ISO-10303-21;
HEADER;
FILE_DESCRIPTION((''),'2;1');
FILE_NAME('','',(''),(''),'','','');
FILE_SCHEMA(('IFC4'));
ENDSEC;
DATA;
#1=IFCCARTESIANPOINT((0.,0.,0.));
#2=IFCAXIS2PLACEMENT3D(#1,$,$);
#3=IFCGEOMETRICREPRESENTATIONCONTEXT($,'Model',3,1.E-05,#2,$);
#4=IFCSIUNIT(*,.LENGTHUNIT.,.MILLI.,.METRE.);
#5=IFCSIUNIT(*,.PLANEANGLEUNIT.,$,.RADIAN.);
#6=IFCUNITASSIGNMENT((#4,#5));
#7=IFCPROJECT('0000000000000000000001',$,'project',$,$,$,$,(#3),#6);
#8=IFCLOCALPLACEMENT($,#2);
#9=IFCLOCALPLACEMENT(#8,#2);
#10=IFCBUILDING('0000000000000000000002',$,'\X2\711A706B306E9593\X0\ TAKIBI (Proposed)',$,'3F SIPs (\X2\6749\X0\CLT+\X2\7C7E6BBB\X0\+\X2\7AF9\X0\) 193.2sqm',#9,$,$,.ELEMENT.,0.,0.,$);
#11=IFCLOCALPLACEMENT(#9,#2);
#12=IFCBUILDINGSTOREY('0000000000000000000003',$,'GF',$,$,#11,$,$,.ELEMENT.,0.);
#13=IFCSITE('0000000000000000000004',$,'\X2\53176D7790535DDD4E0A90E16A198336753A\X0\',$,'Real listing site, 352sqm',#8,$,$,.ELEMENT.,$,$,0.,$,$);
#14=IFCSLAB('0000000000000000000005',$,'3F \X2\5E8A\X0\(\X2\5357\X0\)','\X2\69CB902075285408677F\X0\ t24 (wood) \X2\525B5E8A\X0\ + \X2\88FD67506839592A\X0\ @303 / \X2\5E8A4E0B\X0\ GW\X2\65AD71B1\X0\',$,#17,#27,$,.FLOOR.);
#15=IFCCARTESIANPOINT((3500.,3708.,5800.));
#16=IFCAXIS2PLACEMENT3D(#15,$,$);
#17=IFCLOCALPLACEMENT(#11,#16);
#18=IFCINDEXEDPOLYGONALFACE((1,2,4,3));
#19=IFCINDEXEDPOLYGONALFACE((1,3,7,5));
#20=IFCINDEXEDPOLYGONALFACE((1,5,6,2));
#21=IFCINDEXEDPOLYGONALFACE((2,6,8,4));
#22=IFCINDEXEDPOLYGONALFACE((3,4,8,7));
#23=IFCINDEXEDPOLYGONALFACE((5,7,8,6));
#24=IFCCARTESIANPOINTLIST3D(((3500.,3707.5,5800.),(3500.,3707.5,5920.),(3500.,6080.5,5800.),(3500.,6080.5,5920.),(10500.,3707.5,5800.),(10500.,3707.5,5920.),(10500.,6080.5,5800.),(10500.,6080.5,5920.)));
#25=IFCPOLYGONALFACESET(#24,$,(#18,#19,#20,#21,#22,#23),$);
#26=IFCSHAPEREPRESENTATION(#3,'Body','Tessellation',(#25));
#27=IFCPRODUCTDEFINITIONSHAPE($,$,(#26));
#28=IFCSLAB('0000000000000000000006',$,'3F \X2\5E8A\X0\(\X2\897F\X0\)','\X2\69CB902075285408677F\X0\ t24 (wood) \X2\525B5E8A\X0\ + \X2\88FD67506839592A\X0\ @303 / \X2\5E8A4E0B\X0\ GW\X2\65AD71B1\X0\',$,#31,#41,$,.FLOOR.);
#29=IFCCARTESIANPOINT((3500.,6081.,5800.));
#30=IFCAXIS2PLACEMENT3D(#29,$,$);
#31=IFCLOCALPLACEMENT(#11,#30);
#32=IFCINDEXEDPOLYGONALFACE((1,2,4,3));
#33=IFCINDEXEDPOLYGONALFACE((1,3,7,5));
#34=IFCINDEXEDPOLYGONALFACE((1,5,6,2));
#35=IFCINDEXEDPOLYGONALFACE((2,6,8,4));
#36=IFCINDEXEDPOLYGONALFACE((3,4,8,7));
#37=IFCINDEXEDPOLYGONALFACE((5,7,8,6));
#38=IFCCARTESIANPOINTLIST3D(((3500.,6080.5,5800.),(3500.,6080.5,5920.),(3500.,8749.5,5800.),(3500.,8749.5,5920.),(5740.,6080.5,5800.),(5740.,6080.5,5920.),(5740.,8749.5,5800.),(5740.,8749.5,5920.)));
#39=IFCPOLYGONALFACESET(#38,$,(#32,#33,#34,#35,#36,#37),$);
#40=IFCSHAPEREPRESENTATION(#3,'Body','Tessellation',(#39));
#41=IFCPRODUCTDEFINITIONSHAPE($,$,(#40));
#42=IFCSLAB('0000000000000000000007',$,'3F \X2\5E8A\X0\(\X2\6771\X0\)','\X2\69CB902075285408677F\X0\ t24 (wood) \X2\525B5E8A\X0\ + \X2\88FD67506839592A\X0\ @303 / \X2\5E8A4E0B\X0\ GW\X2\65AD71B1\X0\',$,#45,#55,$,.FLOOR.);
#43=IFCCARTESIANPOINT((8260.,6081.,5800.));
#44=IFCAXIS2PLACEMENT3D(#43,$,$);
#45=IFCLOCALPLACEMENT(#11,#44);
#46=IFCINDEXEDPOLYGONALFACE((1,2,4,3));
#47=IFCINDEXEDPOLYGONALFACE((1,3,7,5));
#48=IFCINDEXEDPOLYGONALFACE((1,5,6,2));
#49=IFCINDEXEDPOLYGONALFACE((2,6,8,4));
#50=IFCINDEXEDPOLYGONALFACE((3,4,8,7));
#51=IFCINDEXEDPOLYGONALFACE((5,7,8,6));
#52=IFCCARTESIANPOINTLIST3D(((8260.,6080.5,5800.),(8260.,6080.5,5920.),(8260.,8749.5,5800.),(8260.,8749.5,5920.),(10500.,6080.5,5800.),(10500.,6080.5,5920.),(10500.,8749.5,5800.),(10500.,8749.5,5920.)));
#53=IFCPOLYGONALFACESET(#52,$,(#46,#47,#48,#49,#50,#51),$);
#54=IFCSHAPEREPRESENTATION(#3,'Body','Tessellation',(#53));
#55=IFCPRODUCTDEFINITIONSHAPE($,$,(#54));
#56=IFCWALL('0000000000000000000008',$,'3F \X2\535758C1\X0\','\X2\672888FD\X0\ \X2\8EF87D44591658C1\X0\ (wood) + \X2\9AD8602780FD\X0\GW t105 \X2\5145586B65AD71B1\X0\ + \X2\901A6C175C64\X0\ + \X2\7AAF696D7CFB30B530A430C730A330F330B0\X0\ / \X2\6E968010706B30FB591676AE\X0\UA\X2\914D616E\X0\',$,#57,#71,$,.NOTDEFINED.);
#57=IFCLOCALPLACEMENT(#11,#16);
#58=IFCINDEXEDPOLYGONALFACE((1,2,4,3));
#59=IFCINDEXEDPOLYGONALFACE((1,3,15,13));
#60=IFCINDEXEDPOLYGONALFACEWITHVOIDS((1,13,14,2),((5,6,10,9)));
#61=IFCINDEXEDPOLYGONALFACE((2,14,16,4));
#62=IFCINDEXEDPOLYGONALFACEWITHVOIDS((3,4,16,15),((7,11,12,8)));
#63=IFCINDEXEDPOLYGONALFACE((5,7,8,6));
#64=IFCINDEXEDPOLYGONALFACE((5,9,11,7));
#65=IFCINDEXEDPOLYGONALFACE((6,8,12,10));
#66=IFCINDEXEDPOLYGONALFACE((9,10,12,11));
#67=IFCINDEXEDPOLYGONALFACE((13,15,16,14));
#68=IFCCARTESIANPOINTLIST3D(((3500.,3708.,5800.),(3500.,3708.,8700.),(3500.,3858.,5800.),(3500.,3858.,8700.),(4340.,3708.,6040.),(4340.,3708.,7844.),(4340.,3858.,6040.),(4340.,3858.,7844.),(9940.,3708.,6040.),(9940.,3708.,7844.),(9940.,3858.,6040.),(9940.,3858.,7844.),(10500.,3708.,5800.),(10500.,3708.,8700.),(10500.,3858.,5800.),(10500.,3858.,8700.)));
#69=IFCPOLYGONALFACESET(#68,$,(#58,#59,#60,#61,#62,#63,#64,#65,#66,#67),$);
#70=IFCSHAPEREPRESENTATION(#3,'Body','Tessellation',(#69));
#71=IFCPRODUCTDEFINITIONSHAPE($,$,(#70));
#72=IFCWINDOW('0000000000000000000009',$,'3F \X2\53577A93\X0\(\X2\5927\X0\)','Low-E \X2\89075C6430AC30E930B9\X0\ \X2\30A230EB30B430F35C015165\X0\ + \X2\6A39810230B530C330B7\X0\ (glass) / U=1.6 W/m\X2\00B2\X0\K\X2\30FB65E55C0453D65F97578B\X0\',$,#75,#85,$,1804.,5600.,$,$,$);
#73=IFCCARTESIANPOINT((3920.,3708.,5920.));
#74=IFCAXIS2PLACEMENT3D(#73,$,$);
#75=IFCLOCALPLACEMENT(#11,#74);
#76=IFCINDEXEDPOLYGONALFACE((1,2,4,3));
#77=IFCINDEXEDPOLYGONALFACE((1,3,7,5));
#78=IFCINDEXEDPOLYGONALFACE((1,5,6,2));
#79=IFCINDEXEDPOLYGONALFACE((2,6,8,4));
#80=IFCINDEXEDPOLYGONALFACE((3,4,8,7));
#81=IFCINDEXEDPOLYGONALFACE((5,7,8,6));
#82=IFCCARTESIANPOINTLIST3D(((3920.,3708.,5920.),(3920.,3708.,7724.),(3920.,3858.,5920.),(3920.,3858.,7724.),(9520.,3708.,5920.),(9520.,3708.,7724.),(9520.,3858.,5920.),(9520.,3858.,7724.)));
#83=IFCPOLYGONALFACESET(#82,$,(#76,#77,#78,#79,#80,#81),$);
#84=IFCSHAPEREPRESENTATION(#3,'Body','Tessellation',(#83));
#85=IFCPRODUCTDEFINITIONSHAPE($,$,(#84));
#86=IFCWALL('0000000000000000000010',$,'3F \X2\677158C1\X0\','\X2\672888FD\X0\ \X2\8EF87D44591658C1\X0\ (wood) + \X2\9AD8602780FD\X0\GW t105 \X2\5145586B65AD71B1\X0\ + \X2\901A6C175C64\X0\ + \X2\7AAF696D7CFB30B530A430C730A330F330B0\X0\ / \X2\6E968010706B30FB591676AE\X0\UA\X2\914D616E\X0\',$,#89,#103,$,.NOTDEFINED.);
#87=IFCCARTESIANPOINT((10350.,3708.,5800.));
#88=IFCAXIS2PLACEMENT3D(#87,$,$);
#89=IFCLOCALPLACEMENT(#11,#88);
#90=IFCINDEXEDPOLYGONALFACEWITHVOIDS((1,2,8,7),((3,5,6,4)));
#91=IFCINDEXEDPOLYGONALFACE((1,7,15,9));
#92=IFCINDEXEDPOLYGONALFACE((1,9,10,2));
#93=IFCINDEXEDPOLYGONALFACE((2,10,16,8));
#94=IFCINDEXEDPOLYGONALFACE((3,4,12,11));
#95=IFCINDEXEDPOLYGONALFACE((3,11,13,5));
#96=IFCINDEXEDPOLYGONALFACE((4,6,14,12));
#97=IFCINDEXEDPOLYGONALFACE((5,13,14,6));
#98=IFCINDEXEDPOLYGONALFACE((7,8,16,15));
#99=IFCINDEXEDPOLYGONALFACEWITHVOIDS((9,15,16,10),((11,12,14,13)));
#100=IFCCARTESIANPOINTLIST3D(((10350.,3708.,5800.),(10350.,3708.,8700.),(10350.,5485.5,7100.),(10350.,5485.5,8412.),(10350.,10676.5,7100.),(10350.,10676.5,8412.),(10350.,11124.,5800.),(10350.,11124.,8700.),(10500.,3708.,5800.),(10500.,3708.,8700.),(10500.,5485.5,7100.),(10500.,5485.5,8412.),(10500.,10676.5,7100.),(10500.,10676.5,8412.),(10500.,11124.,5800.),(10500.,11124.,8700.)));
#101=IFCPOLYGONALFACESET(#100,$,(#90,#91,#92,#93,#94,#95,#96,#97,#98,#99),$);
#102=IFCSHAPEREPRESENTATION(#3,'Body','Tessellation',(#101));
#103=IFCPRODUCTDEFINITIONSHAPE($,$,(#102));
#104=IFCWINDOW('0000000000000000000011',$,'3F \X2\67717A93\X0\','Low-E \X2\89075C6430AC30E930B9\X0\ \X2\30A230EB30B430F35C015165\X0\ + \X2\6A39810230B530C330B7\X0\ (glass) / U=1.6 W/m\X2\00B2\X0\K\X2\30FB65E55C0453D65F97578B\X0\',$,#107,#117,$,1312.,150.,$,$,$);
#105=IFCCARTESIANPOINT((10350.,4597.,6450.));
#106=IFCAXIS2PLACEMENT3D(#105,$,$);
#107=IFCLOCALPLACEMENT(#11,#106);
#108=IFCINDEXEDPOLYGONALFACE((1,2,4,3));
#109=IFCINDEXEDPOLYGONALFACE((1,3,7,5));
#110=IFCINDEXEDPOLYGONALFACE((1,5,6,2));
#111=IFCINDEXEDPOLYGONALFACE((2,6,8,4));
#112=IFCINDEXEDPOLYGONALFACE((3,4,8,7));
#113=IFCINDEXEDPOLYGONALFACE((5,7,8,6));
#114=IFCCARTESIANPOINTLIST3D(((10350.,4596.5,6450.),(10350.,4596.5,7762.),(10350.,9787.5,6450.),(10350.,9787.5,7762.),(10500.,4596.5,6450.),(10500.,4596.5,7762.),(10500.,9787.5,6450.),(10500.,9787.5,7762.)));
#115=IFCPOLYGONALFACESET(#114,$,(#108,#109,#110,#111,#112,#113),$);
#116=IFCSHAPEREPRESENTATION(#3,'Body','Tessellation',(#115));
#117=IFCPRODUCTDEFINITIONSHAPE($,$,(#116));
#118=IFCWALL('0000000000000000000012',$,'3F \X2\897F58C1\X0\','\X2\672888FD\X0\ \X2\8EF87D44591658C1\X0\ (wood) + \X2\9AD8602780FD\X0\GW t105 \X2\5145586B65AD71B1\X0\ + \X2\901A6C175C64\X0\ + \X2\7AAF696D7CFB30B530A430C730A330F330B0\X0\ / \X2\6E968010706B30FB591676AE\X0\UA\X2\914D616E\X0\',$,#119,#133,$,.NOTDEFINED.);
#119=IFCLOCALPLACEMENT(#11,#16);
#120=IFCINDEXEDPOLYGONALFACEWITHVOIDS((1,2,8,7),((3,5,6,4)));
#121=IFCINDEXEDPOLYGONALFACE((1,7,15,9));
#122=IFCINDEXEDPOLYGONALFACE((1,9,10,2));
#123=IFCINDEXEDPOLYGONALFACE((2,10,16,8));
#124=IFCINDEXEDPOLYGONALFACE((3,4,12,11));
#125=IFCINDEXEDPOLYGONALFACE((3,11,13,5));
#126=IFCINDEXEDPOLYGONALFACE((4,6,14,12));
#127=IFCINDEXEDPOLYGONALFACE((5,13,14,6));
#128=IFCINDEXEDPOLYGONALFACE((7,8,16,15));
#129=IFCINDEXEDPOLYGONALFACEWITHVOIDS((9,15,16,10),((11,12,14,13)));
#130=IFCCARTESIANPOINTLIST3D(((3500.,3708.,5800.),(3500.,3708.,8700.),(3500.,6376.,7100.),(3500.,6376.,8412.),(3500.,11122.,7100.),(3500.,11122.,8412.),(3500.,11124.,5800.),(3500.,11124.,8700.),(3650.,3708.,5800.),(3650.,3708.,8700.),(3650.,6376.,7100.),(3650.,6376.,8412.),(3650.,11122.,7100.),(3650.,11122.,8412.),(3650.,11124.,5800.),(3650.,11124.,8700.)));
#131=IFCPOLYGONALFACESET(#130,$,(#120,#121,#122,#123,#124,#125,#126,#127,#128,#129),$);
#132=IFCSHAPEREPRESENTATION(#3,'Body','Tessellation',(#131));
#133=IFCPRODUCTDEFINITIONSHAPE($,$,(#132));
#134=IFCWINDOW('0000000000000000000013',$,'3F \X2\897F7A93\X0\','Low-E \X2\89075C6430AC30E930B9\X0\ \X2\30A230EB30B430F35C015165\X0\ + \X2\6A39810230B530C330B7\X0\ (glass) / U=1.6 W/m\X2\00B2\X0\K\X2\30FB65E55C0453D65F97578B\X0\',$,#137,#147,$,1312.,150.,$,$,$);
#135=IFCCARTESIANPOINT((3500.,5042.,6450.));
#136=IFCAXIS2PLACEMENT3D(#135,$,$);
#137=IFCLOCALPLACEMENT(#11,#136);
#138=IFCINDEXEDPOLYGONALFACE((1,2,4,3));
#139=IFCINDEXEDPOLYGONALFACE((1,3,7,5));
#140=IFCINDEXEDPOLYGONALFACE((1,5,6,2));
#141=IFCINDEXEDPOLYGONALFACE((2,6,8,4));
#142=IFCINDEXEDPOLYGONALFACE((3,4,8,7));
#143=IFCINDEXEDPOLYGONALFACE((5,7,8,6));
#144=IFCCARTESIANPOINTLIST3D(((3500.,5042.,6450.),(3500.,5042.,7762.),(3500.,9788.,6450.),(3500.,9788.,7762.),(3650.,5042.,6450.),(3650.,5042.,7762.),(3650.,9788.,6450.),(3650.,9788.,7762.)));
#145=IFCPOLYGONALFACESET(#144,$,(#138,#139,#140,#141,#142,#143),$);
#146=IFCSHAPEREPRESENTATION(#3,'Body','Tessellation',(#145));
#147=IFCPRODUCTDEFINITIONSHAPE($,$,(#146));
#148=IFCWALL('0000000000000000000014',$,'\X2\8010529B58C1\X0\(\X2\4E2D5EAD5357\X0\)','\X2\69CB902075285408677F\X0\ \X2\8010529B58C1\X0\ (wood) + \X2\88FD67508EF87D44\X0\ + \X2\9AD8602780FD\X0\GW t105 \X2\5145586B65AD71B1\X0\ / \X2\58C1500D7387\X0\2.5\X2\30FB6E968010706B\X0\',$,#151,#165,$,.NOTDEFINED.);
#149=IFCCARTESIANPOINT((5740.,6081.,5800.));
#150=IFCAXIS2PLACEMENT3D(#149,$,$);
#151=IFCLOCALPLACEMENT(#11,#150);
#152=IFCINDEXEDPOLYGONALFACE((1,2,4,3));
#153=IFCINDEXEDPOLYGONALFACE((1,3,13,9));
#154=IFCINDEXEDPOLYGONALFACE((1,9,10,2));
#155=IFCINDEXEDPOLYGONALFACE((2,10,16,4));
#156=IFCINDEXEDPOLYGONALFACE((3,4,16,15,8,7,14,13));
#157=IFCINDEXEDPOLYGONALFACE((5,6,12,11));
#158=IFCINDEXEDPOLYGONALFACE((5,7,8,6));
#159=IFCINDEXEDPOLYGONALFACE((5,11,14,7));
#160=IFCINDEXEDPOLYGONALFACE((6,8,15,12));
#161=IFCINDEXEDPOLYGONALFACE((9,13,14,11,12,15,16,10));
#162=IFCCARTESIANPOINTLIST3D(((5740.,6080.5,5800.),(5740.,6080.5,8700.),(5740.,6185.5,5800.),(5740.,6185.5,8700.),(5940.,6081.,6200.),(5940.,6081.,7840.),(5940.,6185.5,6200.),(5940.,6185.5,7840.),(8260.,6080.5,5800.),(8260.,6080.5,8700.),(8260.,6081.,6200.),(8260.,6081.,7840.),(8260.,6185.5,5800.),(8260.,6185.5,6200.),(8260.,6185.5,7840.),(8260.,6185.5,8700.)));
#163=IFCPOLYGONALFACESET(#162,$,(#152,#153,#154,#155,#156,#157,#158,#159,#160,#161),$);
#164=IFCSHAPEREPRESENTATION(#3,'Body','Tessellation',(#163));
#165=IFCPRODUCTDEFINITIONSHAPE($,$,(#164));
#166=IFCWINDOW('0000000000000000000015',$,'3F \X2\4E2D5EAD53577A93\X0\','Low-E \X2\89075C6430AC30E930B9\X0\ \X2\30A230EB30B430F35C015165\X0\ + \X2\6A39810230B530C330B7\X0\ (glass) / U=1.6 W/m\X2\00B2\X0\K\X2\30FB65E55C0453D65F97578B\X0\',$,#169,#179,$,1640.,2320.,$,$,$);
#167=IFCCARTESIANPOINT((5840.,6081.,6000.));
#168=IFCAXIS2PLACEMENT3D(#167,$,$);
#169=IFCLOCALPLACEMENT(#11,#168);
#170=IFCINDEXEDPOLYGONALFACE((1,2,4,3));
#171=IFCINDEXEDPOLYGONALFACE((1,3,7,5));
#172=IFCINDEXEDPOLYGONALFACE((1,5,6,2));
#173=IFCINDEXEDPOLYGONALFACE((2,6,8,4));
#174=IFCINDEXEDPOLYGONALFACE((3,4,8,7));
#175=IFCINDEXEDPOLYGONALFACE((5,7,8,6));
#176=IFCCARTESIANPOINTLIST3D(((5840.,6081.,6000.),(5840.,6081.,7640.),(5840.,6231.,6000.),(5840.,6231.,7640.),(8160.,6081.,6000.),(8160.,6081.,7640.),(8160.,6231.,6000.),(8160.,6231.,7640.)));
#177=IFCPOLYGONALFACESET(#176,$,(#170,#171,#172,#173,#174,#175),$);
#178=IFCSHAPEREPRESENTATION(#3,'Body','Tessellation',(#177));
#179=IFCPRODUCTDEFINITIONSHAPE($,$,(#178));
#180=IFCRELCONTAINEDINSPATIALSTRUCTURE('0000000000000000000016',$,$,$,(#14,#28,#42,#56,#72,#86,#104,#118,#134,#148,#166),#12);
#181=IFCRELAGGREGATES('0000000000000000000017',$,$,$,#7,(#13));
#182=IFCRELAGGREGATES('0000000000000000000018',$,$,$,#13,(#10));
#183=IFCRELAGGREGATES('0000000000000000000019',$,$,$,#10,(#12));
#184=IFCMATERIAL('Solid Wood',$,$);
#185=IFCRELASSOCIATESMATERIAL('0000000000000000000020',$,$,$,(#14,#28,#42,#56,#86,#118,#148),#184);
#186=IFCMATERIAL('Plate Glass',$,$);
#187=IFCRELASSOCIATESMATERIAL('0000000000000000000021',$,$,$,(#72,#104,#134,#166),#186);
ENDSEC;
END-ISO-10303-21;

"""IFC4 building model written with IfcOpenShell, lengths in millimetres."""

from ifc_helpers import new_model, si_unit, frame, frame_2d, origin, place, context, project, spatial, rectangle, extrude, material, element, fill, save


model = new_model("IFC4")

# Units and contexts
model_context = context("Model", 3, precision=1e-05, world=origin())
ifc_project = project(units=[si_unit("LENGTHUNIT", "METRE", prefix="MILLI"), si_unit("PLANEANGLEUNIT", "RADIAN")], contexts=[model_context])

# Site, building, storey
site_placement = place(None, origin())
site = spatial("IfcSite", under=ifc_project, at=site_placement, Name="北海道川上郡標茶町", ObjectType="Real listing site, 352sqm", CompositionType="ELEMENT", RefElevation=0.0)
building_placement = place(site_placement, origin())
building = spatial("IfcBuilding", under=site, at=building_placement, Name="焚火の間 TAKIBI (Proposed)", ObjectType="3F SIPs (杉CLT+籾殻+竹) 193.2sqm", CompositionType="ELEMENT", ElevationOfRefHeight=0.0, ElevationOfTerrain=0.0)
storey_placement = place(building_placement, origin())
storey = spatial("IfcBuildingStorey", under=building, at=storey_placement, Name="GF", CompositionType="ELEMENT", Elevation=0.0)

# Slabs
ifc_material_1 = material(Name="Solid Wood")
slab_1_placement = place(storey_placement, frame((3500.0, 3708.0, 5800.0)))
element("IfcSlab", 1, at=slab_1_placement, inside=storey, material=ifc_material_1, Name="3F 床(南)", Description="構造用合板 t24 (wood) 剛床 + 製材根太 @303 / 床下 GW断熱", PredefinedType="FLOOR", context=model_context, shape_type="SweptSolid", body=[
    extrude(rectangle(XDim=7000.0, YDim=2373.0, at=frame_2d((3500.0, 1186.0))), frame((3500.0, 3708.0, 5800.0)), (0.0, 0.0, 1.0), 120.0),
])
slab_2_placement = place(storey_placement, frame((3500.0, 6081.0, 5800.0)))
element("IfcSlab", 2, at=slab_2_placement, inside=storey, material=ifc_material_1, Name="3F 床(西)", Description="構造用合板 t24 (wood) 剛床 + 製材根太 @303 / 床下 GW断熱", PredefinedType="FLOOR", context=model_context, shape_type="SweptSolid", body=[
    extrude(rectangle(XDim=2240.0, YDim=2669.0, at=frame_2d((1120.0, 1334.0))), frame((3500.0, 6081.0, 5800.0)), (0.0, 0.0, 1.0), 120.0),
])
slab_3_placement = place(storey_placement, frame((8260.0, 6081.0, 5800.0)))
element("IfcSlab", 3, at=slab_3_placement, inside=storey, material=ifc_material_1, Name="3F 床(東)", Description="構造用合板 t24 (wood) 剛床 + 製材根太 @303 / 床下 GW断熱", PredefinedType="FLOOR", context=model_context, shape_type="SweptSolid", body=[
    extrude(rectangle(XDim=2240.0, YDim=2669.0, at=frame_2d((1120.0, 1334.0))), frame((8260.0, 6081.0, 5800.0)), (0.0, 0.0, 1.0), 120.0),
])

# Walls, openings, windows
wall_1_placement = place(storey_placement, frame((3500.0, 3708.0, 5800.0)))
wall_1 = element("IfcWall", 4, at=wall_1_placement, inside=storey, material=ifc_material_1, Name="3F 南壁", Description="木製 軸組外壁 (wood) + 高性能GW t105 充填断熱 + 通気層 + 窯業系サイディング / 準耐火・外皮UA配慮", PredefinedType="NOTDEFINED", context=model_context, shape_type="SweptSolid", body=[
    extrude(rectangle(XDim=7000.0, YDim=150.0, at=frame_2d((3500.0, 75.0))), frame((3500.0, 3708.0, 5800.0)), (0.0, 0.0, 1.0), 2900.0),
])
opening_1_placement = place(storey_placement, frame((3920.0, 3708.0, 5920.0)))
opening_1 = element("IfcOpeningElement", 5, at=opening_1_placement, cuts=wall_1, PredefinedType="NOTDEFINED", context=model_context, shape_type="SweptSolid", body=[
    extrude(rectangle(XDim=5600.0, YDim=150.0, at=frame_2d((2800.0, 75.0))), frame((3920.0, 3708.0, 5920.0)), (0.0, 0.0, 1.0), 1804.0),
])
ifc_material_2 = material(Name="Plate Glass")
window_1_placement = place(storey_placement, frame((3920.0, 3708.0, 5920.0)))
window_1 = element("IfcWindow", 6, at=window_1_placement, inside=storey, material=ifc_material_2, Name="3F 南窓(大)", Description="Low-E 複層ガラス アルゴン封入 + 樹脂サッシ (glass) / U=1.6 W/m²K・日射取得型", OverallHeight=1804.0, OverallWidth=5600.0, context=model_context, shape_type="SweptSolid", body=[
    extrude(rectangle(XDim=5600.0, YDim=150.0, at=frame_2d((2800.0, 75.0))), frame((3920.0, 3708.0, 5920.0)), (0.0, 0.0, 1.0), 1804.0),
])
fill(opening_1, window_1)
wall_2_placement = place(storey_placement, frame((10350.0, 3708.0, 5800.0)))
wall_2 = element("IfcWall", 7, at=wall_2_placement, inside=storey, material=ifc_material_1, Name="3F 東壁", Description="木製 軸組外壁 (wood) + 高性能GW t105 充填断熱 + 通気層 + 窯業系サイディング / 準耐火・外皮UA配慮", PredefinedType="NOTDEFINED", context=model_context, shape_type="SweptSolid", body=[
    extrude(rectangle(XDim=150.0, YDim=7416.0, at=frame_2d((75.0, 3708.0))), frame((10350.0, 3708.0, 5800.0)), (0.0, 0.0, 1.0), 2900.0),
])
opening_2_placement = place(storey_placement, frame((10350.0, 4597.0, 6450.0)))
opening_2 = element("IfcOpeningElement", 8, at=opening_2_placement, cuts=wall_2, PredefinedType="NOTDEFINED", context=model_context, shape_type="SweptSolid", body=[
    extrude(rectangle(XDim=150.0, YDim=5191.0, at=frame_2d((75.0, 2595.0))), frame((10350.0, 4597.0, 6450.0)), (0.0, 0.0, 1.0), 1312.0),
])
window_2_placement = place(storey_placement, frame((10350.0, 4597.0, 6450.0)))
window_2 = element("IfcWindow", 9, at=window_2_placement, inside=storey, material=ifc_material_2, Name="3F 東窓", Description="Low-E 複層ガラス アルゴン封入 + 樹脂サッシ (glass) / U=1.6 W/m²K・日射取得型", OverallHeight=1312.0, OverallWidth=150.0, context=model_context, shape_type="SweptSolid", body=[
    extrude(rectangle(XDim=150.0, YDim=5191.0, at=frame_2d((75.0, 2595.0))), frame((10350.0, 4597.0, 6450.0)), (0.0, 0.0, 1.0), 1312.0),
])
fill(opening_2, window_2)
wall_3_placement = place(storey_placement, frame((3500.0, 3708.0, 5800.0)))
wall_3 = element("IfcWall", 10, at=wall_3_placement, inside=storey, material=ifc_material_1, Name="3F 西壁", Description="木製 軸組外壁 (wood) + 高性能GW t105 充填断熱 + 通気層 + 窯業系サイディング / 準耐火・外皮UA配慮", PredefinedType="NOTDEFINED", context=model_context, shape_type="SweptSolid", body=[
    extrude(rectangle(XDim=150.0, YDim=7416.0, at=frame_2d((75.0, 3708.0))), frame((3500.0, 3708.0, 5800.0)), (0.0, 0.0, 1.0), 2900.0),
])
opening_3_placement = place(storey_placement, frame((3500.0, 5042.0, 6450.0)))
opening_3 = element("IfcOpeningElement", 11, at=opening_3_placement, cuts=wall_3, PredefinedType="NOTDEFINED", context=model_context, shape_type="SweptSolid", body=[
    extrude(rectangle(XDim=150.0, YDim=4746.0, at=frame_2d((75.0, 2373.0))), frame((3500.0, 5042.0, 6450.0)), (0.0, 0.0, 1.0), 1312.0),
])
window_3_placement = place(storey_placement, frame((3500.0, 5042.0, 6450.0)))
window_3 = element("IfcWindow", 12, at=window_3_placement, inside=storey, material=ifc_material_2, Name="3F 西窓", Description="Low-E 複層ガラス アルゴン封入 + 樹脂サッシ (glass) / U=1.6 W/m²K・日射取得型", OverallHeight=1312.0, OverallWidth=150.0, context=model_context, shape_type="SweptSolid", body=[
    extrude(rectangle(XDim=150.0, YDim=4746.0, at=frame_2d((75.0, 2373.0))), frame((3500.0, 5042.0, 6450.0)), (0.0, 0.0, 1.0), 1312.0),
])
fill(opening_3, window_3)
wall_4_placement = place(storey_placement, frame((5740.0, 6081.0, 5800.0)))
wall_4 = element("IfcWall", 13, at=wall_4_placement, inside=storey, material=ifc_material_1, Name="耐力壁(中庭南)", Description="構造用合板 耐力壁 (wood) + 製材軸組 + 高性能GW t105 充填断熱 / 壁倍率2.5・準耐火", PredefinedType="NOTDEFINED", context=model_context, shape_type="SweptSolid", body=[
    extrude(rectangle(XDim=2520.0, YDim=105.0, at=frame_2d((1260.0, 52.0))), frame((5740.0, 6081.0, 5800.0)), (0.0, 0.0, 1.0), 2900.0),
])
opening_4_placement = place(storey_placement, frame((5840.0, 6081.0, 6000.0)))
opening_4 = element("IfcOpeningElement", 14, at=opening_4_placement, cuts=wall_4, PredefinedType="NOTDEFINED", context=model_context, shape_type="SweptSolid", body=[
    extrude(rectangle(XDim=2320.0, YDim=150.0, at=frame_2d((1160.0, 75.0))), frame((5840.0, 6081.0, 6000.0)), (0.0, 0.0, 1.0), 1640.0),
])
window_4_placement = place(storey_placement, frame((5840.0, 6081.0, 6000.0)))
window_4 = element("IfcWindow", 15, at=window_4_placement, inside=storey, material=ifc_material_2, Name="3F 中庭南窓", Description="Low-E 複層ガラス アルゴン封入 + 樹脂サッシ (glass) / U=1.6 W/m²K・日射取得型", OverallHeight=1640.0, OverallWidth=2320.0, context=model_context, shape_type="SweptSolid", body=[
    extrude(rectangle(XDim=2320.0, YDim=150.0, at=frame_2d((1160.0, 75.0))), frame((5840.0, 6081.0, 6000.0)), (0.0, 0.0, 1.0), 1640.0),
])
fill(opening_4, window_4)

save(model, "model.ifc")
